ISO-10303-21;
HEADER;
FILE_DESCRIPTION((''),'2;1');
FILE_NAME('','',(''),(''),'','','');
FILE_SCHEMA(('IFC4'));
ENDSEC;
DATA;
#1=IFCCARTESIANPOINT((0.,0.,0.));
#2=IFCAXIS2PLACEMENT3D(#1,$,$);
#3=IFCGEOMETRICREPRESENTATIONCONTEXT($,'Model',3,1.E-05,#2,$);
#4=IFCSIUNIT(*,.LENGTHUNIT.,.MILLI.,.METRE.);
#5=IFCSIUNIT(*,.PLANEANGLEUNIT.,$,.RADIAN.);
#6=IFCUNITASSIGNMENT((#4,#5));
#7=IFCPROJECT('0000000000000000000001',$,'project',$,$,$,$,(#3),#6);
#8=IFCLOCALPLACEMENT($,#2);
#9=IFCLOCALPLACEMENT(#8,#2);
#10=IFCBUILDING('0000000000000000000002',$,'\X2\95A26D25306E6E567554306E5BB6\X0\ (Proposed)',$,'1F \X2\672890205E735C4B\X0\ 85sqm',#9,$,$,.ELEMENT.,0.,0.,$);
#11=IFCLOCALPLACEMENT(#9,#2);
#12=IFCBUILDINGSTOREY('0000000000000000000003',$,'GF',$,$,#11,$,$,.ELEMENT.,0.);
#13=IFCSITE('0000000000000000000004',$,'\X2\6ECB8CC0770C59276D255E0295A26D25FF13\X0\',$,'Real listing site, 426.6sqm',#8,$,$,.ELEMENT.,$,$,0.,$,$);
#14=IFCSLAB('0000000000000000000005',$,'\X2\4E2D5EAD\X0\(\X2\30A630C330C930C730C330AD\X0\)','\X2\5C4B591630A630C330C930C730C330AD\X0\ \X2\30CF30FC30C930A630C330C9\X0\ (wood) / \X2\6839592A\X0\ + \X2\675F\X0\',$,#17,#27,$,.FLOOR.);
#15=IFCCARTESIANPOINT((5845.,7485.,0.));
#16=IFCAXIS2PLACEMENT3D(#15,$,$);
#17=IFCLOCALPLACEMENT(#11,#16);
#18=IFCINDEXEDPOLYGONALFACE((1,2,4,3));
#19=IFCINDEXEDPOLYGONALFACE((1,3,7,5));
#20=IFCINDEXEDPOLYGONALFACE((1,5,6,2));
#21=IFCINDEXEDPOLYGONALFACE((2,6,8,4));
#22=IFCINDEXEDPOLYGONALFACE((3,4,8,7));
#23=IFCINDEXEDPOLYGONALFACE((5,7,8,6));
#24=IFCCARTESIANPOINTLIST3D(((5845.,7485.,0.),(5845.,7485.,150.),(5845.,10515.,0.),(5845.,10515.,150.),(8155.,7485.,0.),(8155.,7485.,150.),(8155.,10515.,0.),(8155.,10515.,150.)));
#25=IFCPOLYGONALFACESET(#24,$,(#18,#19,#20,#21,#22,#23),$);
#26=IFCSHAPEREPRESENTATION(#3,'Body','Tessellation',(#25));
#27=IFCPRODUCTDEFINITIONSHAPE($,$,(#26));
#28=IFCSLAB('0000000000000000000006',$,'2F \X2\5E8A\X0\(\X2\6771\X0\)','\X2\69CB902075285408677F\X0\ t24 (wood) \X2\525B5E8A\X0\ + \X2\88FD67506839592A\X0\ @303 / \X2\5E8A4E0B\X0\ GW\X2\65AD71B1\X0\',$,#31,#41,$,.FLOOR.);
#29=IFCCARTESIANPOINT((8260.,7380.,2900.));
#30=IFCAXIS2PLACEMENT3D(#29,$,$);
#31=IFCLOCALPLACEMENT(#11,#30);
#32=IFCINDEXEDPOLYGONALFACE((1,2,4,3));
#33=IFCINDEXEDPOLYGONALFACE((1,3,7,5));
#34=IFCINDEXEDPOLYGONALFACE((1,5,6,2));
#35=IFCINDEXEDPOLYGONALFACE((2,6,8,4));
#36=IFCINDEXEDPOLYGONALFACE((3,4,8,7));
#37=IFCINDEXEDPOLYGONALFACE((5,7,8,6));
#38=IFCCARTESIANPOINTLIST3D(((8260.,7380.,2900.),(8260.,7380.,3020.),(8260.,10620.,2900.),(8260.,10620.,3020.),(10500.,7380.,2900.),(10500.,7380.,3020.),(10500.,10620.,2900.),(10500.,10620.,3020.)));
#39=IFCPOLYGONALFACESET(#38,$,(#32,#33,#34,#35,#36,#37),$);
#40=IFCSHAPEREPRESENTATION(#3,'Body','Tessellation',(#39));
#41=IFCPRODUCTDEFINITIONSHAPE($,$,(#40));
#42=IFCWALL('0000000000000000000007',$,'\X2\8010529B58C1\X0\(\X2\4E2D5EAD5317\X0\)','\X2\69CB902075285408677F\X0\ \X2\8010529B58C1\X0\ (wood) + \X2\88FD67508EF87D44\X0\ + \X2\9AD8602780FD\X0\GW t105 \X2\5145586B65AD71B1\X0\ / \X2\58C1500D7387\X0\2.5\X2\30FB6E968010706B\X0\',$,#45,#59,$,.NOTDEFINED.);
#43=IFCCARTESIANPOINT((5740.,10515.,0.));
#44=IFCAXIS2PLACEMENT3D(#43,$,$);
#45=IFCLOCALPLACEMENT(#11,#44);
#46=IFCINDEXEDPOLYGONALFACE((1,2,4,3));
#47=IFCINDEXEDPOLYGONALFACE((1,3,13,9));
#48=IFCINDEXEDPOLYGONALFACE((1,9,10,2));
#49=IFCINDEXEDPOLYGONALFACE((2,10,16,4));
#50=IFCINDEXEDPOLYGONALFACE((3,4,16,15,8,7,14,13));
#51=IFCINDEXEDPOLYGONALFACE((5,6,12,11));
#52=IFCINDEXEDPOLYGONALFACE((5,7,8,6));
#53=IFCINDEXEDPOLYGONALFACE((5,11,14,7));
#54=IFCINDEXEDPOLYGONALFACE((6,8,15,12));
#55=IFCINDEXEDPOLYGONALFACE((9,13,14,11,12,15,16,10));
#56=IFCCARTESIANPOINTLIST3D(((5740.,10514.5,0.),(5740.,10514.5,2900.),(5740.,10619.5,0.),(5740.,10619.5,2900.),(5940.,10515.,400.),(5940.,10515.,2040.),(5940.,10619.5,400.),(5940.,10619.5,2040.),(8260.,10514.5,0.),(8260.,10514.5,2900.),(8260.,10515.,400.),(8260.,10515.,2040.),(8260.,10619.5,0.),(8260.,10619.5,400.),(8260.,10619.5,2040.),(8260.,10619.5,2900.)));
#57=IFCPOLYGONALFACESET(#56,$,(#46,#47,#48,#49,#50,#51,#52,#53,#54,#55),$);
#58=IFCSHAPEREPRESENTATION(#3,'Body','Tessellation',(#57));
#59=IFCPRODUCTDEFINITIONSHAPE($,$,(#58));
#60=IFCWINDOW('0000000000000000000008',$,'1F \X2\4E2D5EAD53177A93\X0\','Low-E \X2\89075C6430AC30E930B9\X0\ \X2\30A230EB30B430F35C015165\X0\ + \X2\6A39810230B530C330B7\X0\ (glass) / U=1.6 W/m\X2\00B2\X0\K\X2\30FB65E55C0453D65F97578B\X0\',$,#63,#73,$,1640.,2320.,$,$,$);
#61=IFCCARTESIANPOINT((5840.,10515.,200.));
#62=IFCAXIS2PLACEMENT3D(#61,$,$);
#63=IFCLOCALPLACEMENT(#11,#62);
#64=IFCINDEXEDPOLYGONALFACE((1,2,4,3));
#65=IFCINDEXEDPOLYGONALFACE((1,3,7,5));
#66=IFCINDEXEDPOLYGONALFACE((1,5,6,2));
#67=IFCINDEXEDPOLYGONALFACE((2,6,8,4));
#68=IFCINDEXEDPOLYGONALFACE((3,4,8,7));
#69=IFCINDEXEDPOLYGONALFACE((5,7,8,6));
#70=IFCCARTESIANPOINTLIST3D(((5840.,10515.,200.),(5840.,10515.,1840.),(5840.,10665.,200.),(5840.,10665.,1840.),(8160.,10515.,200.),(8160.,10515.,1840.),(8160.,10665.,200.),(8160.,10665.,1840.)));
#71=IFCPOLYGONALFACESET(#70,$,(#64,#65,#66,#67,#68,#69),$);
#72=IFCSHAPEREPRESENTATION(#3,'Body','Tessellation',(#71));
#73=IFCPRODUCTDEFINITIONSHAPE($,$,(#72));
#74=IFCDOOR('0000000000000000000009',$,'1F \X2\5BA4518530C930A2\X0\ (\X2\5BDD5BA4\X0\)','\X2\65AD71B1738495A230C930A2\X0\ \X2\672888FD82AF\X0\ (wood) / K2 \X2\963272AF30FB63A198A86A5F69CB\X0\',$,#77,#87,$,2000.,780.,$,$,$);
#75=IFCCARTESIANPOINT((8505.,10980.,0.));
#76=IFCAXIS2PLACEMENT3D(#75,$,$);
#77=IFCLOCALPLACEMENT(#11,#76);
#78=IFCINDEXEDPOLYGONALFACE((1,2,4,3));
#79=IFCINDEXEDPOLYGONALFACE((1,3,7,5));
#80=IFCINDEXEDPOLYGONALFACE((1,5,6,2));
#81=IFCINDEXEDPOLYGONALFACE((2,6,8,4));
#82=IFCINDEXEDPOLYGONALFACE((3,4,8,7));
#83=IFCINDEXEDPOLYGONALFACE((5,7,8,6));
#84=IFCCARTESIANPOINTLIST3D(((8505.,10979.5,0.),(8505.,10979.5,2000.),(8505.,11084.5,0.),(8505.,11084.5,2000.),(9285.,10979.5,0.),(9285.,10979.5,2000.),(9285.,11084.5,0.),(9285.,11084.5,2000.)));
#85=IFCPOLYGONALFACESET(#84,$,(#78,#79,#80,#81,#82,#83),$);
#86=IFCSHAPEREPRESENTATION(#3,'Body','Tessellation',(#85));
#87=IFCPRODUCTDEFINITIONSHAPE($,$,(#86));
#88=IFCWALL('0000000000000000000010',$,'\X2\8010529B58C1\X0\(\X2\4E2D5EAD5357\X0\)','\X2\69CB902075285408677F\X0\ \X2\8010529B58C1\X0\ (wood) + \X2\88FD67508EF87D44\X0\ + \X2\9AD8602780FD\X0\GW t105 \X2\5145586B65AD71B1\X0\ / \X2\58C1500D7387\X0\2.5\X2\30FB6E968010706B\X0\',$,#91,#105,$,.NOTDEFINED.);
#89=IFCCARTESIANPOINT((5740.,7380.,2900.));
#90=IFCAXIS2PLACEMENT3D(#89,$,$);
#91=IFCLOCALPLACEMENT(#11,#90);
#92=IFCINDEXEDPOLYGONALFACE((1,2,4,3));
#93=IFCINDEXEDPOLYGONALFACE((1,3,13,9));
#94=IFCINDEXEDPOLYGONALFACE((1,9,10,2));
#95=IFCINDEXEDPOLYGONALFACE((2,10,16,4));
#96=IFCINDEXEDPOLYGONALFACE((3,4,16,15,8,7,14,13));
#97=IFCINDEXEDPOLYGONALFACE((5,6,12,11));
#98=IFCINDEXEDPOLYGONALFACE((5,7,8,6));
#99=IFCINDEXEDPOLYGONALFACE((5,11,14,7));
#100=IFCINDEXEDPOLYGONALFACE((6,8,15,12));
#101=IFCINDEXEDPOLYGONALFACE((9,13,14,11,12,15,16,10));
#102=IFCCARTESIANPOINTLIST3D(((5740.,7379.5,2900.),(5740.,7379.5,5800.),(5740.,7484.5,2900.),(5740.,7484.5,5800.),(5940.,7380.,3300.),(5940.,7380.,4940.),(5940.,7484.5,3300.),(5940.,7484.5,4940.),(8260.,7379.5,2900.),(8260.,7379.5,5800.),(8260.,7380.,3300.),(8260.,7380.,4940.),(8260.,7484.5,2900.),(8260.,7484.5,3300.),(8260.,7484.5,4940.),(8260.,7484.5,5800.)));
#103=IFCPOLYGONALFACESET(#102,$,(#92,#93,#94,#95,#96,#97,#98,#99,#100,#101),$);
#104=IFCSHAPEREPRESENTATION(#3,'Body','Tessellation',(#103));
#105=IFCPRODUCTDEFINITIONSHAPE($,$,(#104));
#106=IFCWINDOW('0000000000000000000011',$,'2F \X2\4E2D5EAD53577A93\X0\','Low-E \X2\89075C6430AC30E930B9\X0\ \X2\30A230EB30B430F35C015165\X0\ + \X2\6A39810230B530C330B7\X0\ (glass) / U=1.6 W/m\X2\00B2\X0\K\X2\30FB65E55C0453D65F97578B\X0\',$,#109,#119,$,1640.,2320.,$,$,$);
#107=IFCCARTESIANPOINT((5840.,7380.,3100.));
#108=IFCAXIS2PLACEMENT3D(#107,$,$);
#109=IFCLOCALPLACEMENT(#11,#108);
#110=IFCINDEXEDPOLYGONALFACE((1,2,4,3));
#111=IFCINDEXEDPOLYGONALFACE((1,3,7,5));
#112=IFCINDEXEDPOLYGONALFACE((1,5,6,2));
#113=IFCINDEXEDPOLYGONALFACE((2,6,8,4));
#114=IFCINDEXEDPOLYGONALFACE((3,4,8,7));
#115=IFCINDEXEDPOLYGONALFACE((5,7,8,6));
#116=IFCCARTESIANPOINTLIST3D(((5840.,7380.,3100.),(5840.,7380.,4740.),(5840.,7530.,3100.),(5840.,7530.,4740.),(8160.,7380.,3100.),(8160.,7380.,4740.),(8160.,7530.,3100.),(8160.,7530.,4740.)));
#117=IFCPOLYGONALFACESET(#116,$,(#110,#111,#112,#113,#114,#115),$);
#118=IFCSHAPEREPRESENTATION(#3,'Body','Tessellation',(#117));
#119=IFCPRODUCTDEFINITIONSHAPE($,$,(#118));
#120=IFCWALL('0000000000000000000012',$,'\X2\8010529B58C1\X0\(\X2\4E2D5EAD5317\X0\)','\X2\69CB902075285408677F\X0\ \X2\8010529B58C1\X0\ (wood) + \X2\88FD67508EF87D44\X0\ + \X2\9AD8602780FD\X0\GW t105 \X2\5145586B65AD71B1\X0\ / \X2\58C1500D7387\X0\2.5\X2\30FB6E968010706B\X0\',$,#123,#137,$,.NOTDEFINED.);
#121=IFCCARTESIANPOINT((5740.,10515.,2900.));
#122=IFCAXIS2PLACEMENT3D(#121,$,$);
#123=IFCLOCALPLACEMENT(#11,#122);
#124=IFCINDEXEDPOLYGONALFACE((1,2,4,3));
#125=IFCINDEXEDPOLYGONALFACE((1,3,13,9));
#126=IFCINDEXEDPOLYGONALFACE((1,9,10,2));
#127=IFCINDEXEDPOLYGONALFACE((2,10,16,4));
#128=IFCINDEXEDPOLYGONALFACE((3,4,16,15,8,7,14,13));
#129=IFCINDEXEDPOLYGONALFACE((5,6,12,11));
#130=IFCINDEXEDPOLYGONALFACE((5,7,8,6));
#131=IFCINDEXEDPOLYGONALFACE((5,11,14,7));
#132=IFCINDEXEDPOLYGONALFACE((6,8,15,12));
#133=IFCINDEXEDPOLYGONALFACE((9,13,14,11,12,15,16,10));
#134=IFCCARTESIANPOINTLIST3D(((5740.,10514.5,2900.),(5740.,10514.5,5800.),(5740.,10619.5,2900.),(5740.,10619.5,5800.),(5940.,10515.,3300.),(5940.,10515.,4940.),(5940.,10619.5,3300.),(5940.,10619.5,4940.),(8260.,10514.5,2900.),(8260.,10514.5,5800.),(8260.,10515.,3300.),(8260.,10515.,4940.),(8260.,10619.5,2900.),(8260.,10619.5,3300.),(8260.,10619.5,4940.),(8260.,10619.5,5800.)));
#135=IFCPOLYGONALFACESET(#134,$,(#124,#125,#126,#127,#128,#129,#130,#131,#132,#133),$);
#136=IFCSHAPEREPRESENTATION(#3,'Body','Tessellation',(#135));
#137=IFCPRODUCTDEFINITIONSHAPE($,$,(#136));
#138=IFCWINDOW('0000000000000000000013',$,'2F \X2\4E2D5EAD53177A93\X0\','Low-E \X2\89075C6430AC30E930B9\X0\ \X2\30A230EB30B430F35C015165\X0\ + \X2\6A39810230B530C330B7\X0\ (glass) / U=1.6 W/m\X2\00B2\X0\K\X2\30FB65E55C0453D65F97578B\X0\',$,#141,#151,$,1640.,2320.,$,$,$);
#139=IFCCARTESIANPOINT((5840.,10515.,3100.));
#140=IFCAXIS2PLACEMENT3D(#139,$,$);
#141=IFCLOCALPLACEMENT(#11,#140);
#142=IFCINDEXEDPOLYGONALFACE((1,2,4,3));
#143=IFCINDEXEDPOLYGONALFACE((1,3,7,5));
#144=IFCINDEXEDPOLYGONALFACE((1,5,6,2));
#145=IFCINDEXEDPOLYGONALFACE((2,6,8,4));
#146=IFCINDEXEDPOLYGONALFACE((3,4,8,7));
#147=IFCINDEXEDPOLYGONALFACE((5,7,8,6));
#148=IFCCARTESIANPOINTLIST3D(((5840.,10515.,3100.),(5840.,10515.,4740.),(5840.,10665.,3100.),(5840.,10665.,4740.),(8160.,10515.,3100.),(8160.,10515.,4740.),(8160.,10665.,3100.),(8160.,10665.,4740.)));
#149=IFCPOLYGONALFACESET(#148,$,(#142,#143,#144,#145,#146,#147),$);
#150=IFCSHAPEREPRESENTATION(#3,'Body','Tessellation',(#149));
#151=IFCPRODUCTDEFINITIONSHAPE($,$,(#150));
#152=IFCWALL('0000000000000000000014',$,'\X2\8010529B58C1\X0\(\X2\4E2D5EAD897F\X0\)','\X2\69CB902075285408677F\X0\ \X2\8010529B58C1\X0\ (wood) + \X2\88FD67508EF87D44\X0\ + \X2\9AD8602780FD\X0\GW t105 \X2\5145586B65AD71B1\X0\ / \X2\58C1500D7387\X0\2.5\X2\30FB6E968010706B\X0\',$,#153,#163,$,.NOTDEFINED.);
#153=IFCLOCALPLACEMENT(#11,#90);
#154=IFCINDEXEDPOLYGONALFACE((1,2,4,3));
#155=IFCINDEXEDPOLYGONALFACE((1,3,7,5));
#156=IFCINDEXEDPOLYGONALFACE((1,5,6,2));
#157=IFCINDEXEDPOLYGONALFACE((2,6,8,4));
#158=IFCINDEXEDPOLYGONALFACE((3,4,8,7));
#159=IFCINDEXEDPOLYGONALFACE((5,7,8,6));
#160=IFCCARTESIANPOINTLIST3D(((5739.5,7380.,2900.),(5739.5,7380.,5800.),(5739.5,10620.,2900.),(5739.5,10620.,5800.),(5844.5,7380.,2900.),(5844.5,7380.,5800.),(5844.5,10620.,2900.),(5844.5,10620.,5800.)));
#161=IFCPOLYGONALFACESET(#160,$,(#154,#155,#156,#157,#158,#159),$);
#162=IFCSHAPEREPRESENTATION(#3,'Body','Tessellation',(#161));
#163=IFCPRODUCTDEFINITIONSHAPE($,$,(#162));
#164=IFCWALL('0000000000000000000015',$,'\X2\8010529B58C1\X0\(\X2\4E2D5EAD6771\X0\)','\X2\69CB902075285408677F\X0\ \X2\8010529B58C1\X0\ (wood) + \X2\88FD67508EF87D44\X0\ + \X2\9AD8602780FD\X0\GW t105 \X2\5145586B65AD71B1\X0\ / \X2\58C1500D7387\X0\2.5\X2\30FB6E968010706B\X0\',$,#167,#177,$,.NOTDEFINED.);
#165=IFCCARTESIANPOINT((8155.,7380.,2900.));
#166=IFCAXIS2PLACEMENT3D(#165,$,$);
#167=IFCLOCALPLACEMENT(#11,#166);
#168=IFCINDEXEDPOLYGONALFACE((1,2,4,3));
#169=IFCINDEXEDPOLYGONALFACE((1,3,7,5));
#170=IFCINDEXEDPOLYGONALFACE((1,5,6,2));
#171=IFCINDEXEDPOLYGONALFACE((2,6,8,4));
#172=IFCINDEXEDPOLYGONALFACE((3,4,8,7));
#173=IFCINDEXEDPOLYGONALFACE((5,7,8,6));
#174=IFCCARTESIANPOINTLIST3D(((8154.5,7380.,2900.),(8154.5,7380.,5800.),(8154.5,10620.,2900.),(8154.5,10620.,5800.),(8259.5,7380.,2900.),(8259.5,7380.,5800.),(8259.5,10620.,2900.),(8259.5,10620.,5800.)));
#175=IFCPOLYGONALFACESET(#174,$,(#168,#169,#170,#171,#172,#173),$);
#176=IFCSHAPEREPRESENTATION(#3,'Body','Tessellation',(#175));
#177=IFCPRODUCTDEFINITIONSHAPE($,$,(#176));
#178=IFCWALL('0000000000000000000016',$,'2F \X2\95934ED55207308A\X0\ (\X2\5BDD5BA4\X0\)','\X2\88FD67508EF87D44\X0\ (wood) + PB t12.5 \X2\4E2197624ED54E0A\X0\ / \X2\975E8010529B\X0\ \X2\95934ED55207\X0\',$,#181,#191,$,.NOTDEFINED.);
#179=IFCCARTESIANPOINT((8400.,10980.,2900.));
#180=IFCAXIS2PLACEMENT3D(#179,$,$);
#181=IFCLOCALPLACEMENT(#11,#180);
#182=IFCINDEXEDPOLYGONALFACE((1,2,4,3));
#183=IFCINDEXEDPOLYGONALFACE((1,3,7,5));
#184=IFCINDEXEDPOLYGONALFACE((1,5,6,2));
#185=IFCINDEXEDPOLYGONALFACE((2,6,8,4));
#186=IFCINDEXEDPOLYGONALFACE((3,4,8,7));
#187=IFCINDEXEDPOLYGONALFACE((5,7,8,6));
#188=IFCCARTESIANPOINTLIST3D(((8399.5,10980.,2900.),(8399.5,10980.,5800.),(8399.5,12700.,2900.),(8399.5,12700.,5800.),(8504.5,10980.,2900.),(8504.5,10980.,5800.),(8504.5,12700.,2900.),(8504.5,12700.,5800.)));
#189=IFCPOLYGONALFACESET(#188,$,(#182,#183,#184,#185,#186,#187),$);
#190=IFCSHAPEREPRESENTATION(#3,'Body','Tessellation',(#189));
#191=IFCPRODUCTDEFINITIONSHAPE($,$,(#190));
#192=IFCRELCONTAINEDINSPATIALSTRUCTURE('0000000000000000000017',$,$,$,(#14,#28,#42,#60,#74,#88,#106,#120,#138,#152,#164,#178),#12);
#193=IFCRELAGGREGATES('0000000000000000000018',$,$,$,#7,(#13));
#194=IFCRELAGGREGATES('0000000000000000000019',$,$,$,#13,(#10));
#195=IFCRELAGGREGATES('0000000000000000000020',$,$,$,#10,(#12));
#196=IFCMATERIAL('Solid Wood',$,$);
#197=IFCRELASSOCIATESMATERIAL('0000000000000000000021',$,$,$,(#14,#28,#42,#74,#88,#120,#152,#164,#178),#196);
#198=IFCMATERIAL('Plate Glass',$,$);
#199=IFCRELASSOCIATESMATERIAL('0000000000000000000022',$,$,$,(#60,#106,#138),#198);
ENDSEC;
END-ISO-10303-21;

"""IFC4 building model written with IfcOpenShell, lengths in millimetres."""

from ifc_helpers import new_model, si_unit, frame, frame_2d, origin, place, context, project, spatial, rectangle, extrude, material, element, fill, save


model = new_model("IFC4")

# Units and contexts
model_context = context("Model", 3, precision=1e-05, world=origin())
ifc_project = project(units=[si_unit("LENGTHUNIT", "METRE", prefix="MILLI"), si_unit("PLANEANGLEUNIT", "RADIAN")], contexts=[model_context])

# Site, building, storey
site_placement = place(None, origin())
site = spatial("IfcSite", under=ifc_project, at=site_placement, Name="滋賀県大津市関津３", ObjectType="Real listing site, 426.6sqm", CompositionType="ELEMENT", RefElevation=0.0)
building_placement = place(site_placement, origin())
building = spatial("IfcBuilding", under=site, at=building_placement, Name="関津の湖畔の家 (Proposed)", ObjectType="1F 木造平屋 85sqm", CompositionType="ELEMENT", ElevationOfRefHeight=0.0, ElevationOfTerrain=0.0)
storey_placement = place(building_placement, origin())
storey = spatial("IfcBuildingStorey", under=building, at=storey_placement, Name="GF", CompositionType="ELEMENT", Elevation=0.0)

# Slabs
ifc_material_1 = material(Name="Solid Wood")
slab_1_placement = place(storey_placement, frame((5845.0, 7485.0, 0.0)))
element("IfcSlab", 1, at=slab_1_placement, inside=storey, material=ifc_material_1, Name="中庭(ウッドデッキ)", Description="屋外ウッドデッキ ハードウッド (wood) / 根太 + 束", PredefinedType="FLOOR", context=model_context, shape_type="SweptSolid", body=[
    extrude(rectangle(XDim=2310.0, YDim=3030.0, at=frame_2d((1155.0, 1515.0))), frame((5845.0, 7485.0, 0.0)), (0.0, 0.0, 1.0), 150.0),
])
slab_2_placement = place(storey_placement, frame((8260.0, 7380.0, 2900.0)))
element("IfcSlab", 2, at=slab_2_placement, inside=storey, material=ifc_material_1, Name="2F 床(東)", Description="構造用合板 t24 (wood) 剛床 + 製材根太 @303 / 床下 GW断熱", PredefinedType="FLOOR", context=model_context, shape_type="SweptSolid", body=[
    extrude(rectangle(XDim=2240.0, YDim=3240.0, at=frame_2d((1120.0, 1620.0))), frame((8260.0, 7380.0, 2900.0)), (0.0, 0.0, 1.0), 120.0),
])

# Wall, opening, window
wall_1_placement = place(storey_placement, frame((5740.0, 10515.0, 0.0)))
wall_1 = element("IfcWall", 3, at=wall_1_placement, inside=storey, material=ifc_material_1, Name="耐力壁(中庭北)", Description="構造用合板 耐力壁 (wood) + 製材軸組 + 高性能GW t105 充填断熱 / 壁倍率2.5・準耐火", PredefinedType="NOTDEFINED", context=model_context, shape_type="SweptSolid", body=[
    extrude(rectangle(XDim=2520.0, YDim=105.0, at=frame_2d((1260.0, 52.0))), frame((5740.0, 10515.0, 0.0)), (0.0, 0.0, 1.0), 2900.0),
])
opening_1_placement = place(storey_placement, frame((5840.0, 10515.0, 200.0)))
opening_1 = element("IfcOpeningElement", 4, at=opening_1_placement, cuts=wall_1, PredefinedType="NOTDEFINED", context=model_context, shape_type="SweptSolid", body=[
    extrude(rectangle(XDim=2320.0, YDim=150.0, at=frame_2d((1160.0, 75.0))), frame((5840.0, 10515.0, 200.0)), (0.0, 0.0, 1.0), 1640.0),
])
ifc_material_2 = material(Name="Plate Glass")
window_1_placement = place(storey_placement, frame((5840.0, 10515.0, 200.0)))
window_1 = element("IfcWindow", 5, at=window_1_placement, inside=storey, material=ifc_material_2, Name="1F 中庭北窓", Description="Low-E 複層ガラス アルゴン封入 + 樹脂サッシ (glass) / U=1.6 W/m²K・日射取得型", OverallHeight=1640.0, OverallWidth=2320.0, context=model_context, shape_type="SweptSolid", body=[
    extrude(rectangle(XDim=2320.0, YDim=150.0, at=frame_2d((1160.0, 75.0))), frame((5840.0, 10515.0, 200.0)), (0.0, 0.0, 1.0), 1640.0),
])
fill(opening_1, window_1)

# Door
door_1_placement = place(storey_placement, frame((8505.0, 10980.0, 0.0)))
element("IfcDoor", 6, at=door_1_placement, inside=storey, material=ifc_material_1, Name="1F 室内ドア (寝室)", Description="断熱玄関ドア 木製芯 (wood) / K2 防犯・採風機構", OverallHeight=2000.0, OverallWidth=780.0, context=model_context, shape_type="SweptSolid", body=[
    extrude(rectangle(XDim=780.0, YDim=105.0, at=frame_2d((390.0, 52.0))), frame((8505.0, 10980.0, 0.0)), (0.0, 0.0, 1.0), 2000.0),
])

# Walls, openings, windows
wall_2_placement = place(storey_placement, frame((5740.0, 7380.0, 2900.0)))
wall_2 = element("IfcWall", 7, at=wall_2_placement, inside=storey, material=ifc_material_1, Name="耐力壁(中庭南)", Description="構造用合板 耐力壁 (wood) + 製材軸組 + 高性能GW t105 充填断熱 / 壁倍率2.5・準耐火", PredefinedType="NOTDEFINED", context=model_context, shape_type="SweptSolid", body=[
    extrude(rectangle(XDim=2520.0, YDim=105.0, at=frame_2d((1260.0, 52.0))), frame((5740.0, 7380.0, 2900.0)), (0.0, 0.0, 1.0), 2900.0),
])
opening_2_placement = place(storey_placement, frame((5840.0, 7380.0, 3100.0)))
opening_2 = element("IfcOpeningElement", 8, at=opening_2_placement, cuts=wall_2, PredefinedType="NOTDEFINED", context=model_context, shape_type="SweptSolid", body=[
    extrude(rectangle(XDim=2320.0, YDim=150.0, at=frame_2d((1160.0, 75.0))), frame((5840.0, 7380.0, 3100.0)), (0.0, 0.0, 1.0), 1640.0),
])
window_2_placement = place(storey_placement, frame((5840.0, 7380.0, 3100.0)))
window_2 = element("IfcWindow", 9, at=window_2_placement, inside=storey, material=ifc_material_2, Name="2F 中庭南窓", Description="Low-E 複層ガラス アルゴン封入 + 樹脂サッシ (glass) / U=1.6 W/m²K・日射取得型", OverallHeight=1640.0, OverallWidth=2320.0, context=model_context, shape_type="SweptSolid", body=[
    extrude(rectangle(XDim=2320.0, YDim=150.0, at=frame_2d((1160.0, 75.0))), frame((5840.0, 7380.0, 3100.0)), (0.0, 0.0, 1.0), 1640.0),
])
fill(opening_2, window_2)
wall_3_placement = place(storey_placement, frame((5740.0, 10515.0, 2900.0)))
wall_3 = element("IfcWall", 10, at=wall_3_placement, inside=storey, material=ifc_material_1, Name="耐力壁(中庭北)", Description="構造用合板 耐力壁 (wood) + 製材軸組 + 高性能GW t105 充填断熱 / 壁倍率2.5・準耐火", PredefinedType="NOTDEFINED", context=model_context, shape_type="SweptSolid", body=[
    extrude(rectangle(XDim=2520.0, YDim=105.0, at=frame_2d((1260.0, 52.0))), frame((5740.0, 10515.0, 2900.0)), (0.0, 0.0, 1.0), 2900.0),
])
opening_3_placement = place(storey_placement, frame((5840.0, 10515.0, 3100.0)))
opening_3 = element("IfcOpeningElement", 11, at=opening_3_placement, cuts=wall_3, PredefinedType="NOTDEFINED", context=model_context, shape_type="SweptSolid", body=[
    extrude(rectangle(XDim=2320.0, YDim=150.0, at=frame_2d((1160.0, 75.0))), frame((5840.0, 10515.0, 3100.0)), (0.0, 0.0, 1.0), 1640.0),
])
window_3_placement = place(storey_placement, frame((5840.0, 10515.0, 3100.0)))
window_3 = element("IfcWindow", 12, at=window_3_placement, inside=storey, material=ifc_material_2, Name="2F 中庭北窓", Description="Low-E 複層ガラス アルゴン封入 + 樹脂サッシ (glass) / U=1.6 W/m²K・日射取得型", OverallHeight=1640.0, OverallWidth=2320.0, context=model_context, shape_type="SweptSolid", body=[
    extrude(rectangle(XDim=2320.0, YDim=150.0, at=frame_2d((1160.0, 75.0))), frame((5840.0, 10515.0, 3100.0)), (0.0, 0.0, 1.0), 1640.0),
])
fill(opening_3, window_3)

# Walls
wall_4_placement = place(storey_placement, frame((5740.0, 7380.0, 2900.0)))
element("IfcWall", 13, at=wall_4_placement, inside=storey, material=ifc_material_1, Name="耐力壁(中庭西)", Description="構造用合板 耐力壁 (wood) + 製材軸組 + 高性能GW t105 充填断熱 / 壁倍率2.5・準耐火", PredefinedType="NOTDEFINED", context=model_context, shape_type="SweptSolid", body=[
    extrude(rectangle(XDim=105.0, YDim=3240.0, at=frame_2d((52.0, 1620.0))), frame((5740.0, 7380.0, 2900.0)), (0.0, 0.0, 1.0), 2900.0),
])
wall_5_placement = place(storey_placement, frame((8155.0, 7380.0, 2900.0)))
element("IfcWall", 14, at=wall_5_placement, inside=storey, material=ifc_material_1, Name="耐力壁(中庭東)", Description="構造用合板 耐力壁 (wood) + 製材軸組 + 高性能GW t105 充填断熱 / 壁倍率2.5・準耐火", PredefinedType="NOTDEFINED", context=model_context, shape_type="SweptSolid", body=[
    extrude(rectangle(XDim=105.0, YDim=3240.0, at=frame_2d((52.0, 1620.0))), frame((8155.0, 7380.0, 2900.0)), (0.0, 0.0, 1.0), 2900.0),
])
wall_6_placement = place(storey_placement, frame((8400.0, 10980.0, 2900.0)))
element("IfcWall", 15, at=wall_6_placement, inside=storey, material=ifc_material_1, Name="2F 間仕切り (寝室)", Description="製材軸組 (wood) + PB t12.5 両面仕上 / 非耐力 間仕切", PredefinedType="NOTDEFINED", context=model_context, shape_type="SweptSolid", body=[
    extrude(rectangle(XDim=105.0, YDim=1720.0, at=frame_2d((52.0, 860.0))), frame((8400.0, 10980.0, 2900.0)), (0.0, 0.0, 1.0), 2900.0),
])

save(model, "model.ifc")
